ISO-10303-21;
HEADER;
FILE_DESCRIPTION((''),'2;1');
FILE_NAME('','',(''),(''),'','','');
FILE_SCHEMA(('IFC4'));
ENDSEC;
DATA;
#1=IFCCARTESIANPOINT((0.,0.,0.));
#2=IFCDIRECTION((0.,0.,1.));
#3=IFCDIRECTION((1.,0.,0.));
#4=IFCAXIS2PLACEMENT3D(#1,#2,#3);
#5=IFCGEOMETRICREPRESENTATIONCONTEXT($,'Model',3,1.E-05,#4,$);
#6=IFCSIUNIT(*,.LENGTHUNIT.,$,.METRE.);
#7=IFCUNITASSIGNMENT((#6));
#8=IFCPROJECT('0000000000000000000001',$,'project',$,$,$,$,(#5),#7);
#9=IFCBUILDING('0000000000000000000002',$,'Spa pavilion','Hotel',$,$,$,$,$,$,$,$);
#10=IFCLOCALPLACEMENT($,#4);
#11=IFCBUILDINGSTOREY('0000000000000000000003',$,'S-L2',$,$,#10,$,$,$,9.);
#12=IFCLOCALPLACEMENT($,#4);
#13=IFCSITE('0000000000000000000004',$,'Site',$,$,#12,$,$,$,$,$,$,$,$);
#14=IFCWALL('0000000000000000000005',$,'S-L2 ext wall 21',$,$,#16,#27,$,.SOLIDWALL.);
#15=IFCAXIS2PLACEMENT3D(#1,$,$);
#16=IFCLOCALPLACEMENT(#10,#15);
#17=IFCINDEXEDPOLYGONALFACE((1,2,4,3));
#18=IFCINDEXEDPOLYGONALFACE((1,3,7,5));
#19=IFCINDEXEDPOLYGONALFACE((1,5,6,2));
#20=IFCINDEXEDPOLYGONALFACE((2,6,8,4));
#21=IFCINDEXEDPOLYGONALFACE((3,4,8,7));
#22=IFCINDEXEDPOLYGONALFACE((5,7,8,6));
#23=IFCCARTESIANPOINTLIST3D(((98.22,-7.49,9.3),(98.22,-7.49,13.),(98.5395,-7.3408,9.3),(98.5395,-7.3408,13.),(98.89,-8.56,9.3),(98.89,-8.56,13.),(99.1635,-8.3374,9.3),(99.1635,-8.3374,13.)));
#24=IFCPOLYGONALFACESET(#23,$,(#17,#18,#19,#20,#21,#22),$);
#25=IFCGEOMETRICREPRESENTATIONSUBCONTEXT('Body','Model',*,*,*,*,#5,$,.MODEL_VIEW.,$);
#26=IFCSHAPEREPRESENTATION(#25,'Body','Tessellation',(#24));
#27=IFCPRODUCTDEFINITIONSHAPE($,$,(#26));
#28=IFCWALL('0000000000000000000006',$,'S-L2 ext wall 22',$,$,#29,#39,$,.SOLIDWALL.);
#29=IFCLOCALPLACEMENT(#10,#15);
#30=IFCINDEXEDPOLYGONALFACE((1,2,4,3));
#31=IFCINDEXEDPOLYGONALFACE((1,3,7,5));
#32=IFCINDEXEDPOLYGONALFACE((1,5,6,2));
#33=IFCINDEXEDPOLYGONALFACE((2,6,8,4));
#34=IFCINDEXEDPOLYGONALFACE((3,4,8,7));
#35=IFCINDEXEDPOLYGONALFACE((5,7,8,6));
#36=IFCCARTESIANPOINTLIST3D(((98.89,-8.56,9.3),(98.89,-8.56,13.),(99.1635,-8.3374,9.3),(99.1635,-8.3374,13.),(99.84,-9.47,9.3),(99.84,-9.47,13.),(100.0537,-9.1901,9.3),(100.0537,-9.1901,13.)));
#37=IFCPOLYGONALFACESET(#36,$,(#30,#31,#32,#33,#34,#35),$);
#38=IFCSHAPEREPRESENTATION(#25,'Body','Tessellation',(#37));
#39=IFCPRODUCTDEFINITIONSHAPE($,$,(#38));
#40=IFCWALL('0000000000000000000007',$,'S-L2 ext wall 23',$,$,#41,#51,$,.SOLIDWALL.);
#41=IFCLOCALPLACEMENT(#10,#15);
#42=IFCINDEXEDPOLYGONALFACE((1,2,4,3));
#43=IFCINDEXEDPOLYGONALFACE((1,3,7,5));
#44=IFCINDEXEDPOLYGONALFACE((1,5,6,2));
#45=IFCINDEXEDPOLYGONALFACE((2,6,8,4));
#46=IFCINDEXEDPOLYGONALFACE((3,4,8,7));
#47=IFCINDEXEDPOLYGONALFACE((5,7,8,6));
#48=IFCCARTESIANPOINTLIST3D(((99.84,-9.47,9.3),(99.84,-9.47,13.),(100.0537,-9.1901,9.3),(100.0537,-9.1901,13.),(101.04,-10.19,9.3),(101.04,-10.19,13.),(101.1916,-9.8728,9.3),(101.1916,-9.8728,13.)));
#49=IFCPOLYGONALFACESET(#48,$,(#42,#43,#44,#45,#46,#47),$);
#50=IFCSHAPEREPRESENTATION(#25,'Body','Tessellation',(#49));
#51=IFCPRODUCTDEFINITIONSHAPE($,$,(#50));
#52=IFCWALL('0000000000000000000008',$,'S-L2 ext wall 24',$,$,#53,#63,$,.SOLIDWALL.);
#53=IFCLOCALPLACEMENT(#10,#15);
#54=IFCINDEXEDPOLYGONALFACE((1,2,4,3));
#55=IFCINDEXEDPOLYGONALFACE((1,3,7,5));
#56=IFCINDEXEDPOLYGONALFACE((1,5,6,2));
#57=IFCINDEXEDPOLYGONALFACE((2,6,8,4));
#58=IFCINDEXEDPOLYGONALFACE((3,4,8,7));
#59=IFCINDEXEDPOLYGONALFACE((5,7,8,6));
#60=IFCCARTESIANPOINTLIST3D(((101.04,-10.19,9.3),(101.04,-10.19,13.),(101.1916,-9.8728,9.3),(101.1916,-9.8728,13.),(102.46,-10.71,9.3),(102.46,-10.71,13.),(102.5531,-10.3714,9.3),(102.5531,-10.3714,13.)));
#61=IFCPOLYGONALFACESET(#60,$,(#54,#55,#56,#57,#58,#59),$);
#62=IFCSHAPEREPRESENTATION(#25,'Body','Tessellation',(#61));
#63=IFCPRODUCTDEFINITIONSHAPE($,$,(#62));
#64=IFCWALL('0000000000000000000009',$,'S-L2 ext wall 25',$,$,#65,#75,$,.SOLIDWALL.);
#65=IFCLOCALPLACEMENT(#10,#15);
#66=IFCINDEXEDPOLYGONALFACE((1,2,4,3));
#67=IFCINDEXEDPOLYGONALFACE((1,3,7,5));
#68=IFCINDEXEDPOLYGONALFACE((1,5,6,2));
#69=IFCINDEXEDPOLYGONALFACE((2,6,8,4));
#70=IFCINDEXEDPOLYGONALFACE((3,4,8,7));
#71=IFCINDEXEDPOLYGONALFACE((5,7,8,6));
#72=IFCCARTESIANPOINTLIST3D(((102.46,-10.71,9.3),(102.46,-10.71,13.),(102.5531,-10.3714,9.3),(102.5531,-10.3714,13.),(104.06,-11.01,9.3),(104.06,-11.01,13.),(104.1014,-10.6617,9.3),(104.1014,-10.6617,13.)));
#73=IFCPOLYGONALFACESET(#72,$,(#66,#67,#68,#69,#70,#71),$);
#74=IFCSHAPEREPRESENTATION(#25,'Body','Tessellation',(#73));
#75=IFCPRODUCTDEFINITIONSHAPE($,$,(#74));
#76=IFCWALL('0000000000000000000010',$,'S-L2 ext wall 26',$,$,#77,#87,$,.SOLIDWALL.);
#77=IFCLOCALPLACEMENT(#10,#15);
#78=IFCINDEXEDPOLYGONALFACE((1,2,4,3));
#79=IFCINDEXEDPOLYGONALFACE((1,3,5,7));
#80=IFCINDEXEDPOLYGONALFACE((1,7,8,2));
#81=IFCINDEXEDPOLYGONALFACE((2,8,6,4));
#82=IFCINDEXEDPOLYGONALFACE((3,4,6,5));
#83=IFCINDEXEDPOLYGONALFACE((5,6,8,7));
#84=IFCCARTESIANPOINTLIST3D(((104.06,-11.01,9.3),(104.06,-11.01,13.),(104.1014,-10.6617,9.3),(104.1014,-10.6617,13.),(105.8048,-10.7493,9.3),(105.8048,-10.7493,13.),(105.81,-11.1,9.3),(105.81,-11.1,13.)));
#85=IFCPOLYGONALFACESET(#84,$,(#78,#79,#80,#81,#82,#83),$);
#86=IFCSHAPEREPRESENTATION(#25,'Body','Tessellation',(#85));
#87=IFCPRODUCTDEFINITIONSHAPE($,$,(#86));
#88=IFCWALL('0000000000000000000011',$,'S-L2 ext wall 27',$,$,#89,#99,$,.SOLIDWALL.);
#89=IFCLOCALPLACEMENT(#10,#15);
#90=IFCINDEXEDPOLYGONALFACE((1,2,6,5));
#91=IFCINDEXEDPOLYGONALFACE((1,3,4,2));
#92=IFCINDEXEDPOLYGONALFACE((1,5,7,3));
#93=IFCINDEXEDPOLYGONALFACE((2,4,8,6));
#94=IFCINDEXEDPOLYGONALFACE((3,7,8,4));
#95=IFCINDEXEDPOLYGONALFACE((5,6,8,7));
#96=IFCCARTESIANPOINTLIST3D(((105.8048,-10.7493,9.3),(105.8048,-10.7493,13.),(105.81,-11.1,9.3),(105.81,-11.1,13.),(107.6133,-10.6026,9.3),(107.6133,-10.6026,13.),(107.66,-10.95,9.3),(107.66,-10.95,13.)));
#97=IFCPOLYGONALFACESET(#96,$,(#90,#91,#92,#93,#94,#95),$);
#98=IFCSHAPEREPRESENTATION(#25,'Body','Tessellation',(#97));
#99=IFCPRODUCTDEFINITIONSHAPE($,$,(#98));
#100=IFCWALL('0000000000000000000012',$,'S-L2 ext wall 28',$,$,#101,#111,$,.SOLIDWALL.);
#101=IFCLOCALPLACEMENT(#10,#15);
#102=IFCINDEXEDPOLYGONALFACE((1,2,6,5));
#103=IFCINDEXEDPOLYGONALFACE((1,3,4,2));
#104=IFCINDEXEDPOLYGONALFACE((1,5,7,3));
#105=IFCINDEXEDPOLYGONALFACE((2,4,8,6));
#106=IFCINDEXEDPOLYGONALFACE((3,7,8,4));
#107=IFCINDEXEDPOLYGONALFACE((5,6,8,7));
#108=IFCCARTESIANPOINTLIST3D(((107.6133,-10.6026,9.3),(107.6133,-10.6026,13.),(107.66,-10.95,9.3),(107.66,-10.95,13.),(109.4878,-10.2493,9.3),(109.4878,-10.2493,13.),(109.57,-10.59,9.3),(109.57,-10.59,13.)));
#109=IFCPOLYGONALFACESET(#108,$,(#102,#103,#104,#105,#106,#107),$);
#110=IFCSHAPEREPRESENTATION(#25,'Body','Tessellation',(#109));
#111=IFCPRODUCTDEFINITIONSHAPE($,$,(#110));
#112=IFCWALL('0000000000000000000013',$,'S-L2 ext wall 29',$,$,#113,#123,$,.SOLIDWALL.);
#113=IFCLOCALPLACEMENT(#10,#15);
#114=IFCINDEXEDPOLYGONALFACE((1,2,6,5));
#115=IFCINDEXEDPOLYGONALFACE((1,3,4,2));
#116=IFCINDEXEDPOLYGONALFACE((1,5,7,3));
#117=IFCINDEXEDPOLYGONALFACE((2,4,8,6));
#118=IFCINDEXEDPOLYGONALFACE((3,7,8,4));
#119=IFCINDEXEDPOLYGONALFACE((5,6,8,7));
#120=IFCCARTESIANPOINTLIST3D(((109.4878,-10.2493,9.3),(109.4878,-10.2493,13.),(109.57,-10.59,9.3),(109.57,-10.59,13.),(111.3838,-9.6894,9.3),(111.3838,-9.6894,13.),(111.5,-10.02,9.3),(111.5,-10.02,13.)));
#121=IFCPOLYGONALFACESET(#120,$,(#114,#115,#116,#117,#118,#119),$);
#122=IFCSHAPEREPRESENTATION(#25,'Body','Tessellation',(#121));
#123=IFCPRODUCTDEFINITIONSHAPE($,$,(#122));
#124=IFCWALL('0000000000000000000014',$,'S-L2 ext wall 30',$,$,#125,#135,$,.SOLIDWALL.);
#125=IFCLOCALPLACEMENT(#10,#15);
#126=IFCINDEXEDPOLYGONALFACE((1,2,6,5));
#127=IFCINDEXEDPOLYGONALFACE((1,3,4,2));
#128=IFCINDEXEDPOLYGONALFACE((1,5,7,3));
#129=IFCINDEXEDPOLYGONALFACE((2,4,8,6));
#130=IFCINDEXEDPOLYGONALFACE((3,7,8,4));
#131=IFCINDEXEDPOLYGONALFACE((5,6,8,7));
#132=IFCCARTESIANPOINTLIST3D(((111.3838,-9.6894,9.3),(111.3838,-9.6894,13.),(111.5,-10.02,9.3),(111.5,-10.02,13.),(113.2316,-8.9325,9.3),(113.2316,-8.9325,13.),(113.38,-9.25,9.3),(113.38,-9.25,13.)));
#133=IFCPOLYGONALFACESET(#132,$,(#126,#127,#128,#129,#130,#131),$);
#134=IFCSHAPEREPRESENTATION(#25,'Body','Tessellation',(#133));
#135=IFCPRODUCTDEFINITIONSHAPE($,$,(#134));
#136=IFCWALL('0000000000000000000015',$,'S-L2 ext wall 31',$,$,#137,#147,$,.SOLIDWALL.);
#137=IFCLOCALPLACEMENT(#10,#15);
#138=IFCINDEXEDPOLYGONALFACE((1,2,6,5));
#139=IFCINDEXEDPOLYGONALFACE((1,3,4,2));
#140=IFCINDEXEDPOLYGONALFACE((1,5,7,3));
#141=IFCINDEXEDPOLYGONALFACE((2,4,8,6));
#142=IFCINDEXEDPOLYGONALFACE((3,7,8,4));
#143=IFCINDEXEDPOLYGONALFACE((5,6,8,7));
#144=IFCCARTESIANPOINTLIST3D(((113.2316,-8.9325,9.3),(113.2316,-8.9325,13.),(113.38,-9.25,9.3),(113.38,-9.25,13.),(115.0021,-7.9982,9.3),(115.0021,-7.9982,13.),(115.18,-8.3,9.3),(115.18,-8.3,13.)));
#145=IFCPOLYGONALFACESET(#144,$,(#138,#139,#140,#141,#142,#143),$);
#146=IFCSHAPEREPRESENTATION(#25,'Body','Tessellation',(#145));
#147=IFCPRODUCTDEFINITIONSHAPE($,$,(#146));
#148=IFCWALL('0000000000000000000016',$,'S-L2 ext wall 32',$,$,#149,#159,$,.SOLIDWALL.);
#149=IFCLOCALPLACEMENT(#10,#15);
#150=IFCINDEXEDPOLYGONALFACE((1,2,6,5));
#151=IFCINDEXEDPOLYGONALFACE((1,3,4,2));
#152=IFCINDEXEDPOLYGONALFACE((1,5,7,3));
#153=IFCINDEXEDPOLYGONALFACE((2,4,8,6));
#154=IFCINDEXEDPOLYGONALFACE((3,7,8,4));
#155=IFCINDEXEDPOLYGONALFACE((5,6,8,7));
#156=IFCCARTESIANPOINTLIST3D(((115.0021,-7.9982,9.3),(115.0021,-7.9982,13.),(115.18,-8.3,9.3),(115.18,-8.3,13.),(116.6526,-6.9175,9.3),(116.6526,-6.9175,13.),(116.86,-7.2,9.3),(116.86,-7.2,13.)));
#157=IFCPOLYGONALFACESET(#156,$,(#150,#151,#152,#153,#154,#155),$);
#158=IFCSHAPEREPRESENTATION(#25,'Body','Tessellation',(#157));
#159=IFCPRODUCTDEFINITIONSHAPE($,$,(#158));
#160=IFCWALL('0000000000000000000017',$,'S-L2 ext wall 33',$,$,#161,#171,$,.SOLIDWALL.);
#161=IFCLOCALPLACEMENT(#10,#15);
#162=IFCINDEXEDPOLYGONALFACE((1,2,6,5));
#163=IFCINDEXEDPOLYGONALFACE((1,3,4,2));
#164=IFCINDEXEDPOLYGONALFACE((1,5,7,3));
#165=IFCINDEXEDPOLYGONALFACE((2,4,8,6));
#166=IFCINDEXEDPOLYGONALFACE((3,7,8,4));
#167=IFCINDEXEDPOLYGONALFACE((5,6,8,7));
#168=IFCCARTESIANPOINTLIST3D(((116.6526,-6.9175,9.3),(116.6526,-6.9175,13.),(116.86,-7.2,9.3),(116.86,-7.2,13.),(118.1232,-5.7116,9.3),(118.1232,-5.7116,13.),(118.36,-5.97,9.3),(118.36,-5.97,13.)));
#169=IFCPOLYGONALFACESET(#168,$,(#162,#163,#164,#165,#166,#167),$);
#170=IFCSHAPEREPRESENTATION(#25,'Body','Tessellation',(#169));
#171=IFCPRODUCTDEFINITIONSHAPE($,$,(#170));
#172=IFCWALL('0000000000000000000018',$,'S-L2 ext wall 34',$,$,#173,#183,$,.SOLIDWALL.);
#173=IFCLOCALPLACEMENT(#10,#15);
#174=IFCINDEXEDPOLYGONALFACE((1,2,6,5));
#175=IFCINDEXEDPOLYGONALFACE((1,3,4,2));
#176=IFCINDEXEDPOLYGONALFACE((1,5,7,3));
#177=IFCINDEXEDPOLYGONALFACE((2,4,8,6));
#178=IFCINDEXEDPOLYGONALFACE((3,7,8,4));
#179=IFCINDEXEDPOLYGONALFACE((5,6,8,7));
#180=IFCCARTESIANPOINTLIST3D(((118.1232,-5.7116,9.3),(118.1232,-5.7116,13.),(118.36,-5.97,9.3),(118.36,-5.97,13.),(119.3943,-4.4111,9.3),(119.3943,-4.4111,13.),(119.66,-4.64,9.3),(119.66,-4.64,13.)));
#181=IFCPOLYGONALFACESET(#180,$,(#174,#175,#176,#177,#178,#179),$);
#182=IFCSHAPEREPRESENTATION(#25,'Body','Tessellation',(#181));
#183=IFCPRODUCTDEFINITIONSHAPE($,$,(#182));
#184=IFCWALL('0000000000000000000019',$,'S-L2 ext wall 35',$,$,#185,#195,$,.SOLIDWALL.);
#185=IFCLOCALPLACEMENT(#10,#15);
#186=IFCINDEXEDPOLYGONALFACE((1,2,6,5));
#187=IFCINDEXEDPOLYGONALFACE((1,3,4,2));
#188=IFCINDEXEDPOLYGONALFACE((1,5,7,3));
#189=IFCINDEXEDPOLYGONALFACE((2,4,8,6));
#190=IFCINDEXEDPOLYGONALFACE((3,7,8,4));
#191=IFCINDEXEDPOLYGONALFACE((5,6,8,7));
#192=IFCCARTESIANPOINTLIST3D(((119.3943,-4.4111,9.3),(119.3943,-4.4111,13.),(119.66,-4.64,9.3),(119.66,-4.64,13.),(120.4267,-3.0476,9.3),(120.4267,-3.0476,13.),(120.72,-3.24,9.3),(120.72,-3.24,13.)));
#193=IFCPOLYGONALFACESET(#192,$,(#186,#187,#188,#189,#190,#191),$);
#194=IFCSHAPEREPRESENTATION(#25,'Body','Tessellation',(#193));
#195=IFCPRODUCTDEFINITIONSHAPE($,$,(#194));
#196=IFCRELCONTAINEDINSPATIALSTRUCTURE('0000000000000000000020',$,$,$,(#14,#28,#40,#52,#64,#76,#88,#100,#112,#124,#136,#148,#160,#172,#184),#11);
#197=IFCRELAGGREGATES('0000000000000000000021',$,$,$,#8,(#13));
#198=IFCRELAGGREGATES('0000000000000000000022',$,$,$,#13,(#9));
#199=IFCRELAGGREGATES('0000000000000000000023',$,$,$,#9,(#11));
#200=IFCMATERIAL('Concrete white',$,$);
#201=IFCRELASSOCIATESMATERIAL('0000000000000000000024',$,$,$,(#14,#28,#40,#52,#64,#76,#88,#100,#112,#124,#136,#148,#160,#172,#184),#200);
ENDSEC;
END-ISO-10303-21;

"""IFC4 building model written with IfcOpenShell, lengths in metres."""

from ifc_helpers import new_model, si_unit, frame, origin_with_axes, place, context, subcontext, project, spatial, polyline, outline, extrude, material, element, save


model = new_model("IFC4")

# Units and contexts
model_context = context("Model", 3, precision=1e-05, world=origin_with_axes())
body_context = subcontext(model_context, "Body", "Model", "MODEL_VIEW")
ifc_project = project(units=[si_unit("LENGTHUNIT", "METRE")], contexts=[model_context])

# Site, building, storey
site_placement = place(None, origin_with_axes())
site = spatial("IfcSite", under=ifc_project, at=site_placement, Name="Site")
building = spatial("IfcBuilding", under=site, Name="Spa pavilion", Description="Hotel")
storey_placement = place(None, origin_with_axes())
storey = spatial("IfcBuildingStorey", under=building, at=storey_placement, Name="S-L2", Elevation=9.0)

# Walls
ifc_material_1 = material(Name="Concrete white")
wall_1_placement = place(storey_placement, origin_with_axes())
element("IfcWall", 1, at=wall_1_placement, inside=storey, material=ifc_material_1, Name="S-L2 ext wall 21", PredefinedType="SOLIDWALL", context=body_context, shape_type="SweptSolid", body=[
    extrude(outline(polyline([(98.22, -7.49), (98.89, -8.56), (99.1635, -8.3374), (98.5395, -7.3408), (98.22, -7.49)])), frame((0.0, 0.0, 9.3), z_axis=(0.0, 0.0, 1.0), x_axis=(1.0, 0.0, 0.0)), (0.0, 0.0, 1.0), 3.7),
])
wall_2_placement = place(storey_placement, origin_with_axes())
element("IfcWall", 2, at=wall_2_placement, inside=storey, material=ifc_material_1, Name="S-L2 ext wall 22", PredefinedType="SOLIDWALL", context=body_context, shape_type="SweptSolid", body=[
    extrude(outline(polyline([(98.89, -8.56), (99.84, -9.47), (100.0537, -9.1901), (99.1635, -8.3374), (98.89, -8.56)])), frame((0.0, 0.0, 9.3), z_axis=(0.0, 0.0, 1.0), x_axis=(1.0, 0.0, 0.0)), (0.0, 0.0, 1.0), 3.7),
])
wall_3_placement = place(storey_placement, origin_with_axes())
element("IfcWall", 3, at=wall_3_placement, inside=storey, material=ifc_material_1, Name="S-L2 ext wall 23", PredefinedType="SOLIDWALL", context=body_context, shape_type="SweptSolid", body=[
    extrude(outline(polyline([(99.84, -9.47), (101.04, -10.19), (101.1916, -9.8728), (100.0537, -9.1901), (99.84, -9.47)])), frame((0.0, 0.0, 9.3), z_axis=(0.0, 0.0, 1.0), x_axis=(1.0, 0.0, 0.0)), (0.0, 0.0, 1.0), 3.7),
])
wall_4_placement = place(storey_placement, origin_with_axes())
element("IfcWall", 4, at=wall_4_placement, inside=storey, material=ifc_material_1, Name="S-L2 ext wall 24", PredefinedType="SOLIDWALL", context=body_context, shape_type="SweptSolid", body=[
    extrude(outline(polyline([(101.04, -10.19), (102.46, -10.71), (102.5531, -10.3714), (101.1916, -9.8728), (101.04, -10.19)])), frame((0.0, 0.0, 9.3), z_axis=(0.0, 0.0, 1.0), x_axis=(1.0, 0.0, 0.0)), (0.0, 0.0, 1.0), 3.7),
])
wall_5_placement = place(storey_placement, origin_with_axes())
element("IfcWall", 5, at=wall_5_placement, inside=storey, material=ifc_material_1, Name="S-L2 ext wall 25", PredefinedType="SOLIDWALL", context=body_context, shape_type="SweptSolid", body=[
    extrude(outline(polyline([(102.46, -10.71), (104.06, -11.01), (104.1014, -10.6617), (102.5531, -10.3714), (102.46, -10.71)])), frame((0.0, 0.0, 9.3), z_axis=(0.0, 0.0, 1.0), x_axis=(1.0, 0.0, 0.0)), (0.0, 0.0, 1.0), 3.7),
])
wall_6_placement = place(storey_placement, origin_with_axes())
element("IfcWall", 6, at=wall_6_placement, inside=storey, material=ifc_material_1, Name="S-L2 ext wall 26", PredefinedType="SOLIDWALL", context=body_context, shape_type="SweptSolid", body=[
    extrude(outline(polyline([(104.06, -11.01), (105.81, -11.1), (105.8048, -10.7493), (104.1014, -10.6617), (104.06, -11.01)])), frame((0.0, 0.0, 9.3), z_axis=(0.0, 0.0, 1.0), x_axis=(1.0, 0.0, 0.0)), (0.0, 0.0, 1.0), 3.7),
])
wall_7_placement = place(storey_placement, origin_with_axes())
element("IfcWall", 7, at=wall_7_placement, inside=storey, material=ifc_material_1, Name="S-L2 ext wall 27", PredefinedType="SOLIDWALL", context=body_context, shape_type="SweptSolid", body=[
    extrude(outline(polyline([(105.81, -11.1), (107.66, -10.95), (107.6133, -10.6026), (105.8048, -10.7493), (105.81, -11.1)])), frame((0.0, 0.0, 9.3), z_axis=(0.0, 0.0, 1.0), x_axis=(1.0, 0.0, 0.0)), (0.0, 0.0, 1.0), 3.7),
])
wall_8_placement = place(storey_placement, origin_with_axes())
element("IfcWall", 8, at=wall_8_placement, inside=storey, material=ifc_material_1, Name="S-L2 ext wall 28", PredefinedType="SOLIDWALL", context=body_context, shape_type="SweptSolid", body=[
    extrude(outline(polyline([(107.66, -10.95), (109.57, -10.59), (109.4878, -10.2493), (107.6133, -10.6026), (107.66, -10.95)])), frame((0.0, 0.0, 9.3), z_axis=(0.0, 0.0, 1.0), x_axis=(1.0, 0.0, 0.0)), (0.0, 0.0, 1.0), 3.7),
])
wall_9_placement = place(storey_placement, origin_with_axes())
element("IfcWall", 9, at=wall_9_placement, inside=storey, material=ifc_material_1, Name="S-L2 ext wall 29", PredefinedType="SOLIDWALL", context=body_context, shape_type="SweptSolid", body=[
    extrude(outline(polyline([(109.57, -10.59), (111.5, -10.02), (111.3838, -9.6894), (109.4878, -10.2493), (109.57, -10.59)])), frame((0.0, 0.0, 9.3), z_axis=(0.0, 0.0, 1.0), x_axis=(1.0, 0.0, 0.0)), (0.0, 0.0, 1.0), 3.7),
])
wall_10_placement = place(storey_placement, origin_with_axes())
element("IfcWall", 10, at=wall_10_placement, inside=storey, material=ifc_material_1, Name="S-L2 ext wall 30", PredefinedType="SOLIDWALL", context=body_context, shape_type="SweptSolid", body=[
    extrude(outline(polyline([(111.5, -10.02), (113.38, -9.25), (113.2316, -8.9325), (111.3838, -9.6894), (111.5, -10.02)])), frame((0.0, 0.0, 9.3), z_axis=(0.0, 0.0, 1.0), x_axis=(1.0, 0.0, 0.0)), (0.0, 0.0, 1.0), 3.7),
])
wall_11_placement = place(storey_placement, origin_with_axes())
element("IfcWall", 11, at=wall_11_placement, inside=storey, material=ifc_material_1, Name="S-L2 ext wall 31", PredefinedType="SOLIDWALL", context=body_context, shape_type="SweptSolid", body=[
    extrude(outline(polyline([(113.38, -9.25), (115.18, -8.3), (115.0021, -7.9982), (113.2316, -8.9325), (113.38, -9.25)])), frame((0.0, 0.0, 9.3), z_axis=(0.0, 0.0, 1.0), x_axis=(1.0, 0.0, 0.0)), (0.0, 0.0, 1.0), 3.7),
])
wall_12_placement = place(storey_placement, origin_with_axes())
element("IfcWall", 12, at=wall_12_placement, inside=storey, material=ifc_material_1, Name="S-L2 ext wall 32", PredefinedType="SOLIDWALL", context=body_context, shape_type="SweptSolid", body=[
    extrude(outline(polyline([(115.18, -8.3), (116.86, -7.2), (116.6526, -6.9175), (115.0021, -7.9982), (115.18, -8.3)])), frame((0.0, 0.0, 9.3), z_axis=(0.0, 0.0, 1.0), x_axis=(1.0, 0.0, 0.0)), (0.0, 0.0, 1.0), 3.7),
])
wall_13_placement = place(storey_placement, origin_with_axes())
element("IfcWall", 13, at=wall_13_placement, inside=storey, material=ifc_material_1, Name="S-L2 ext wall 33", PredefinedType="SOLIDWALL", context=body_context, shape_type="SweptSolid", body=[
    extrude(outline(polyline([(116.86, -7.2), (118.36, -5.97), (118.1232, -5.7116), (116.6526, -6.9175), (116.86, -7.2)])), frame((0.0, 0.0, 9.3), z_axis=(0.0, 0.0, 1.0), x_axis=(1.0, 0.0, 0.0)), (0.0, 0.0, 1.0), 3.7),
])
wall_14_placement = place(storey_placement, origin_with_axes())
element("IfcWall", 14, at=wall_14_placement, inside=storey, material=ifc_material_1, Name="S-L2 ext wall 34", PredefinedType="SOLIDWALL", context=body_context, shape_type="SweptSolid", body=[
    extrude(outline(polyline([(118.36, -5.97), (119.66, -4.64), (119.3943, -4.4111), (118.1232, -5.7116), (118.36, -5.97)])), frame((0.0, 0.0, 9.3), z_axis=(0.0, 0.0, 1.0), x_axis=(1.0, 0.0, 0.0)), (0.0, 0.0, 1.0), 3.7),
])
wall_15_placement = place(storey_placement, origin_with_axes())
element("IfcWall", 15, at=wall_15_placement, inside=storey, material=ifc_material_1, Name="S-L2 ext wall 35", PredefinedType="SOLIDWALL", context=body_context, shape_type="SweptSolid", body=[
    extrude(outline(polyline([(119.66, -4.64), (120.72, -3.24), (120.4267, -3.0476), (119.3943, -4.4111), (119.66, -4.64)])), frame((0.0, 0.0, 9.3), z_axis=(0.0, 0.0, 1.0), x_axis=(1.0, 0.0, 0.0)), (0.0, 0.0, 1.0), 3.7),
])

save(model, "model.ifc")
